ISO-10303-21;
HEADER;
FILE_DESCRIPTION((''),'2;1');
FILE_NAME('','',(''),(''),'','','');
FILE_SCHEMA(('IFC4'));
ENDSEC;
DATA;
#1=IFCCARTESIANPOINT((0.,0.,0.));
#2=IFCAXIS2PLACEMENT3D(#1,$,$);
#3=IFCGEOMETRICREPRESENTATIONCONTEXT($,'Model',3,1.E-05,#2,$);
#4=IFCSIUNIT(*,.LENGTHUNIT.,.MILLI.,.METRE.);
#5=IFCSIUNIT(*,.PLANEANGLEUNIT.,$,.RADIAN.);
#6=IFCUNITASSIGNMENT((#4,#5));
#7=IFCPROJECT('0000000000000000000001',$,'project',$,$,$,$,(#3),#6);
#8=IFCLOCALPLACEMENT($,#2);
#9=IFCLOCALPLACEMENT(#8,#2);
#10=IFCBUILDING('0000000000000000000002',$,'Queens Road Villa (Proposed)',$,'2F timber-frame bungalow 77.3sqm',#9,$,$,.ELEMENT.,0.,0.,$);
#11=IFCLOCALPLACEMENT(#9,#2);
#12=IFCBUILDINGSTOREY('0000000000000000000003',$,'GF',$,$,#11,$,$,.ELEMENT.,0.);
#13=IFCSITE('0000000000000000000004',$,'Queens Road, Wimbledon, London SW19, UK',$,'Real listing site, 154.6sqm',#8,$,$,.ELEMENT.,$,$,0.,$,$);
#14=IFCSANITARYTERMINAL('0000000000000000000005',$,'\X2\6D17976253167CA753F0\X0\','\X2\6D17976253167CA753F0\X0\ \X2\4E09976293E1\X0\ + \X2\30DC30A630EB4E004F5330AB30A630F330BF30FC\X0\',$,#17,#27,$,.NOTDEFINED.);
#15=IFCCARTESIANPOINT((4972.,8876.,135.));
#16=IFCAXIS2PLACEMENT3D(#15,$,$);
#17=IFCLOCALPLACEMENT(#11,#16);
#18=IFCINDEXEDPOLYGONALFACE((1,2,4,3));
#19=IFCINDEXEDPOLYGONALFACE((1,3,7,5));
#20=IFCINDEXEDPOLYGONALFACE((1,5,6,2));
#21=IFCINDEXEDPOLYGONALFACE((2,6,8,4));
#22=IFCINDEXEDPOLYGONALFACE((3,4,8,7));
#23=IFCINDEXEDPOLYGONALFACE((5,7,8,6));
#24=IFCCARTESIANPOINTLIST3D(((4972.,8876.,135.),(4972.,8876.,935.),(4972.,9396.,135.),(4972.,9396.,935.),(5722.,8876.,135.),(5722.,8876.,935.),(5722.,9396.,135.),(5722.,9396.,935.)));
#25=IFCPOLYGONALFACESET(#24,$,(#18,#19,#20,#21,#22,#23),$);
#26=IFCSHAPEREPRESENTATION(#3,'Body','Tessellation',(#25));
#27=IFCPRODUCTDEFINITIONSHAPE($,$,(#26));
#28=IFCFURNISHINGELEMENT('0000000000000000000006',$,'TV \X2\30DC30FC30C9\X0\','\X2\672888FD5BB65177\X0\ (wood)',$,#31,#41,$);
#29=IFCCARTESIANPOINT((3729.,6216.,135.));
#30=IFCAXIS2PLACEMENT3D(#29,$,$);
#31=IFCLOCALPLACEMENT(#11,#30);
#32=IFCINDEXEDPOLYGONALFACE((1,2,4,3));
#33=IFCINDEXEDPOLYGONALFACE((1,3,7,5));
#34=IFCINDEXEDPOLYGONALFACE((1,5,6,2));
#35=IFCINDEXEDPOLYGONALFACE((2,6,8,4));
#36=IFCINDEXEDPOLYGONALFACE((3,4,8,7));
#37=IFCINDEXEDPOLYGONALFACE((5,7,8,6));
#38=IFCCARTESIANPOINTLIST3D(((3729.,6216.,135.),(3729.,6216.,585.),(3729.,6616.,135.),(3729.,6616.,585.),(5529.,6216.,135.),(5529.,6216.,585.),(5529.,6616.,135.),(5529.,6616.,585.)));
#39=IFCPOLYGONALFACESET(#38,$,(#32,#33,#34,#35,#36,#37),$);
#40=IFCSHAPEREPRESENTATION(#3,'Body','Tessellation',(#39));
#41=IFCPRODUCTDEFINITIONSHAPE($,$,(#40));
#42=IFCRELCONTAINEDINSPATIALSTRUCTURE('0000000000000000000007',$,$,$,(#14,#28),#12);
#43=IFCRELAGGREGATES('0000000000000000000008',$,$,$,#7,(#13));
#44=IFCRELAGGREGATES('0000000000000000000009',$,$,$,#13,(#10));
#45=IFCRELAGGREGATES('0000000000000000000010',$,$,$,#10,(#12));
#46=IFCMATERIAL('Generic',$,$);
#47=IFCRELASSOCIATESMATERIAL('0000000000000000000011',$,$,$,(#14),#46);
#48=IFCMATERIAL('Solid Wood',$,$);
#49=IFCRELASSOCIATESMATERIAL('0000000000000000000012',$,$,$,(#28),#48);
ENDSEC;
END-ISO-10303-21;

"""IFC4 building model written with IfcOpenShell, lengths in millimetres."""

from ifc_helpers import new_model, si_unit, frame, frame_2d, origin, place, context, project, spatial, rectangle, extrude, material, element, save


model = new_model("IFC4")

# Units and contexts
model_context = context("Model", 3, precision=1e-05, world=origin())
ifc_project = project(units=[si_unit("LENGTHUNIT", "METRE", prefix="MILLI"), si_unit("PLANEANGLEUNIT", "RADIAN")], contexts=[model_context])

# Site, building, storey
site_placement = place(None, origin())
site = spatial("IfcSite", under=ifc_project, at=site_placement, Name="Queens Road, Wimbledon, London SW19, UK", ObjectType="Real listing site, 154.6sqm", CompositionType="ELEMENT", RefElevation=0.0)
building_placement = place(site_placement, origin())
building = spatial("IfcBuilding", under=site, at=building_placement, Name="Queens Road Villa (Proposed)", ObjectType="2F timber-frame bungalow 77.3sqm", CompositionType="ELEMENT", ElevationOfRefHeight=0.0, ElevationOfTerrain=0.0)
storey_placement = place(building_placement, origin())
storey = spatial("IfcBuildingStorey", under=building, at=storey_placement, Name="GF", CompositionType="ELEMENT", Elevation=0.0)

# Shared definitions
ifc_material_1 = material(Name="Solid Wood")

# Shared definitions
ifc_material_2 = material(Name="Generic")

# Sanitary terminal
sanitary_terminal_1_placement = place(storey_placement, frame((4972.0, 8876.0, 135.0)))
element("IfcSanitaryTerminal", 1, at=sanitary_terminal_1_placement, inside=storey, material=ifc_material_2, Name="洗面化粧台", Description="洗面化粧台 三面鏡 + ボウル一体カウンター", PredefinedType="NOTDEFINED", context=model_context, shape_type="SweptSolid", body=[
    extrude(rectangle(XDim=750.0, YDim=520.0, at=frame_2d((375.0, 260.0))), frame((4972.0, 8876.0, 135.0)), (0.0, 0.0, 1.0), 800.0),
])

# Furnishing element
furnishing_placement = place(storey_placement, frame((3729.0, 6216.0, 135.0)))
element("IfcFurnishingElement", 2, at=furnishing_placement, inside=storey, material=ifc_material_1, Name="TV ボード", Description="木製家具 (wood)", context=model_context, shape_type="SweptSolid", body=[
    extrude(rectangle(XDim=1800.0, YDim=400.0, at=frame_2d((900.0, 200.0))), frame((3729.0, 6216.0, 135.0)), (0.0, 0.0, 1.0), 450.0),
])

save(model, "model.ifc")
